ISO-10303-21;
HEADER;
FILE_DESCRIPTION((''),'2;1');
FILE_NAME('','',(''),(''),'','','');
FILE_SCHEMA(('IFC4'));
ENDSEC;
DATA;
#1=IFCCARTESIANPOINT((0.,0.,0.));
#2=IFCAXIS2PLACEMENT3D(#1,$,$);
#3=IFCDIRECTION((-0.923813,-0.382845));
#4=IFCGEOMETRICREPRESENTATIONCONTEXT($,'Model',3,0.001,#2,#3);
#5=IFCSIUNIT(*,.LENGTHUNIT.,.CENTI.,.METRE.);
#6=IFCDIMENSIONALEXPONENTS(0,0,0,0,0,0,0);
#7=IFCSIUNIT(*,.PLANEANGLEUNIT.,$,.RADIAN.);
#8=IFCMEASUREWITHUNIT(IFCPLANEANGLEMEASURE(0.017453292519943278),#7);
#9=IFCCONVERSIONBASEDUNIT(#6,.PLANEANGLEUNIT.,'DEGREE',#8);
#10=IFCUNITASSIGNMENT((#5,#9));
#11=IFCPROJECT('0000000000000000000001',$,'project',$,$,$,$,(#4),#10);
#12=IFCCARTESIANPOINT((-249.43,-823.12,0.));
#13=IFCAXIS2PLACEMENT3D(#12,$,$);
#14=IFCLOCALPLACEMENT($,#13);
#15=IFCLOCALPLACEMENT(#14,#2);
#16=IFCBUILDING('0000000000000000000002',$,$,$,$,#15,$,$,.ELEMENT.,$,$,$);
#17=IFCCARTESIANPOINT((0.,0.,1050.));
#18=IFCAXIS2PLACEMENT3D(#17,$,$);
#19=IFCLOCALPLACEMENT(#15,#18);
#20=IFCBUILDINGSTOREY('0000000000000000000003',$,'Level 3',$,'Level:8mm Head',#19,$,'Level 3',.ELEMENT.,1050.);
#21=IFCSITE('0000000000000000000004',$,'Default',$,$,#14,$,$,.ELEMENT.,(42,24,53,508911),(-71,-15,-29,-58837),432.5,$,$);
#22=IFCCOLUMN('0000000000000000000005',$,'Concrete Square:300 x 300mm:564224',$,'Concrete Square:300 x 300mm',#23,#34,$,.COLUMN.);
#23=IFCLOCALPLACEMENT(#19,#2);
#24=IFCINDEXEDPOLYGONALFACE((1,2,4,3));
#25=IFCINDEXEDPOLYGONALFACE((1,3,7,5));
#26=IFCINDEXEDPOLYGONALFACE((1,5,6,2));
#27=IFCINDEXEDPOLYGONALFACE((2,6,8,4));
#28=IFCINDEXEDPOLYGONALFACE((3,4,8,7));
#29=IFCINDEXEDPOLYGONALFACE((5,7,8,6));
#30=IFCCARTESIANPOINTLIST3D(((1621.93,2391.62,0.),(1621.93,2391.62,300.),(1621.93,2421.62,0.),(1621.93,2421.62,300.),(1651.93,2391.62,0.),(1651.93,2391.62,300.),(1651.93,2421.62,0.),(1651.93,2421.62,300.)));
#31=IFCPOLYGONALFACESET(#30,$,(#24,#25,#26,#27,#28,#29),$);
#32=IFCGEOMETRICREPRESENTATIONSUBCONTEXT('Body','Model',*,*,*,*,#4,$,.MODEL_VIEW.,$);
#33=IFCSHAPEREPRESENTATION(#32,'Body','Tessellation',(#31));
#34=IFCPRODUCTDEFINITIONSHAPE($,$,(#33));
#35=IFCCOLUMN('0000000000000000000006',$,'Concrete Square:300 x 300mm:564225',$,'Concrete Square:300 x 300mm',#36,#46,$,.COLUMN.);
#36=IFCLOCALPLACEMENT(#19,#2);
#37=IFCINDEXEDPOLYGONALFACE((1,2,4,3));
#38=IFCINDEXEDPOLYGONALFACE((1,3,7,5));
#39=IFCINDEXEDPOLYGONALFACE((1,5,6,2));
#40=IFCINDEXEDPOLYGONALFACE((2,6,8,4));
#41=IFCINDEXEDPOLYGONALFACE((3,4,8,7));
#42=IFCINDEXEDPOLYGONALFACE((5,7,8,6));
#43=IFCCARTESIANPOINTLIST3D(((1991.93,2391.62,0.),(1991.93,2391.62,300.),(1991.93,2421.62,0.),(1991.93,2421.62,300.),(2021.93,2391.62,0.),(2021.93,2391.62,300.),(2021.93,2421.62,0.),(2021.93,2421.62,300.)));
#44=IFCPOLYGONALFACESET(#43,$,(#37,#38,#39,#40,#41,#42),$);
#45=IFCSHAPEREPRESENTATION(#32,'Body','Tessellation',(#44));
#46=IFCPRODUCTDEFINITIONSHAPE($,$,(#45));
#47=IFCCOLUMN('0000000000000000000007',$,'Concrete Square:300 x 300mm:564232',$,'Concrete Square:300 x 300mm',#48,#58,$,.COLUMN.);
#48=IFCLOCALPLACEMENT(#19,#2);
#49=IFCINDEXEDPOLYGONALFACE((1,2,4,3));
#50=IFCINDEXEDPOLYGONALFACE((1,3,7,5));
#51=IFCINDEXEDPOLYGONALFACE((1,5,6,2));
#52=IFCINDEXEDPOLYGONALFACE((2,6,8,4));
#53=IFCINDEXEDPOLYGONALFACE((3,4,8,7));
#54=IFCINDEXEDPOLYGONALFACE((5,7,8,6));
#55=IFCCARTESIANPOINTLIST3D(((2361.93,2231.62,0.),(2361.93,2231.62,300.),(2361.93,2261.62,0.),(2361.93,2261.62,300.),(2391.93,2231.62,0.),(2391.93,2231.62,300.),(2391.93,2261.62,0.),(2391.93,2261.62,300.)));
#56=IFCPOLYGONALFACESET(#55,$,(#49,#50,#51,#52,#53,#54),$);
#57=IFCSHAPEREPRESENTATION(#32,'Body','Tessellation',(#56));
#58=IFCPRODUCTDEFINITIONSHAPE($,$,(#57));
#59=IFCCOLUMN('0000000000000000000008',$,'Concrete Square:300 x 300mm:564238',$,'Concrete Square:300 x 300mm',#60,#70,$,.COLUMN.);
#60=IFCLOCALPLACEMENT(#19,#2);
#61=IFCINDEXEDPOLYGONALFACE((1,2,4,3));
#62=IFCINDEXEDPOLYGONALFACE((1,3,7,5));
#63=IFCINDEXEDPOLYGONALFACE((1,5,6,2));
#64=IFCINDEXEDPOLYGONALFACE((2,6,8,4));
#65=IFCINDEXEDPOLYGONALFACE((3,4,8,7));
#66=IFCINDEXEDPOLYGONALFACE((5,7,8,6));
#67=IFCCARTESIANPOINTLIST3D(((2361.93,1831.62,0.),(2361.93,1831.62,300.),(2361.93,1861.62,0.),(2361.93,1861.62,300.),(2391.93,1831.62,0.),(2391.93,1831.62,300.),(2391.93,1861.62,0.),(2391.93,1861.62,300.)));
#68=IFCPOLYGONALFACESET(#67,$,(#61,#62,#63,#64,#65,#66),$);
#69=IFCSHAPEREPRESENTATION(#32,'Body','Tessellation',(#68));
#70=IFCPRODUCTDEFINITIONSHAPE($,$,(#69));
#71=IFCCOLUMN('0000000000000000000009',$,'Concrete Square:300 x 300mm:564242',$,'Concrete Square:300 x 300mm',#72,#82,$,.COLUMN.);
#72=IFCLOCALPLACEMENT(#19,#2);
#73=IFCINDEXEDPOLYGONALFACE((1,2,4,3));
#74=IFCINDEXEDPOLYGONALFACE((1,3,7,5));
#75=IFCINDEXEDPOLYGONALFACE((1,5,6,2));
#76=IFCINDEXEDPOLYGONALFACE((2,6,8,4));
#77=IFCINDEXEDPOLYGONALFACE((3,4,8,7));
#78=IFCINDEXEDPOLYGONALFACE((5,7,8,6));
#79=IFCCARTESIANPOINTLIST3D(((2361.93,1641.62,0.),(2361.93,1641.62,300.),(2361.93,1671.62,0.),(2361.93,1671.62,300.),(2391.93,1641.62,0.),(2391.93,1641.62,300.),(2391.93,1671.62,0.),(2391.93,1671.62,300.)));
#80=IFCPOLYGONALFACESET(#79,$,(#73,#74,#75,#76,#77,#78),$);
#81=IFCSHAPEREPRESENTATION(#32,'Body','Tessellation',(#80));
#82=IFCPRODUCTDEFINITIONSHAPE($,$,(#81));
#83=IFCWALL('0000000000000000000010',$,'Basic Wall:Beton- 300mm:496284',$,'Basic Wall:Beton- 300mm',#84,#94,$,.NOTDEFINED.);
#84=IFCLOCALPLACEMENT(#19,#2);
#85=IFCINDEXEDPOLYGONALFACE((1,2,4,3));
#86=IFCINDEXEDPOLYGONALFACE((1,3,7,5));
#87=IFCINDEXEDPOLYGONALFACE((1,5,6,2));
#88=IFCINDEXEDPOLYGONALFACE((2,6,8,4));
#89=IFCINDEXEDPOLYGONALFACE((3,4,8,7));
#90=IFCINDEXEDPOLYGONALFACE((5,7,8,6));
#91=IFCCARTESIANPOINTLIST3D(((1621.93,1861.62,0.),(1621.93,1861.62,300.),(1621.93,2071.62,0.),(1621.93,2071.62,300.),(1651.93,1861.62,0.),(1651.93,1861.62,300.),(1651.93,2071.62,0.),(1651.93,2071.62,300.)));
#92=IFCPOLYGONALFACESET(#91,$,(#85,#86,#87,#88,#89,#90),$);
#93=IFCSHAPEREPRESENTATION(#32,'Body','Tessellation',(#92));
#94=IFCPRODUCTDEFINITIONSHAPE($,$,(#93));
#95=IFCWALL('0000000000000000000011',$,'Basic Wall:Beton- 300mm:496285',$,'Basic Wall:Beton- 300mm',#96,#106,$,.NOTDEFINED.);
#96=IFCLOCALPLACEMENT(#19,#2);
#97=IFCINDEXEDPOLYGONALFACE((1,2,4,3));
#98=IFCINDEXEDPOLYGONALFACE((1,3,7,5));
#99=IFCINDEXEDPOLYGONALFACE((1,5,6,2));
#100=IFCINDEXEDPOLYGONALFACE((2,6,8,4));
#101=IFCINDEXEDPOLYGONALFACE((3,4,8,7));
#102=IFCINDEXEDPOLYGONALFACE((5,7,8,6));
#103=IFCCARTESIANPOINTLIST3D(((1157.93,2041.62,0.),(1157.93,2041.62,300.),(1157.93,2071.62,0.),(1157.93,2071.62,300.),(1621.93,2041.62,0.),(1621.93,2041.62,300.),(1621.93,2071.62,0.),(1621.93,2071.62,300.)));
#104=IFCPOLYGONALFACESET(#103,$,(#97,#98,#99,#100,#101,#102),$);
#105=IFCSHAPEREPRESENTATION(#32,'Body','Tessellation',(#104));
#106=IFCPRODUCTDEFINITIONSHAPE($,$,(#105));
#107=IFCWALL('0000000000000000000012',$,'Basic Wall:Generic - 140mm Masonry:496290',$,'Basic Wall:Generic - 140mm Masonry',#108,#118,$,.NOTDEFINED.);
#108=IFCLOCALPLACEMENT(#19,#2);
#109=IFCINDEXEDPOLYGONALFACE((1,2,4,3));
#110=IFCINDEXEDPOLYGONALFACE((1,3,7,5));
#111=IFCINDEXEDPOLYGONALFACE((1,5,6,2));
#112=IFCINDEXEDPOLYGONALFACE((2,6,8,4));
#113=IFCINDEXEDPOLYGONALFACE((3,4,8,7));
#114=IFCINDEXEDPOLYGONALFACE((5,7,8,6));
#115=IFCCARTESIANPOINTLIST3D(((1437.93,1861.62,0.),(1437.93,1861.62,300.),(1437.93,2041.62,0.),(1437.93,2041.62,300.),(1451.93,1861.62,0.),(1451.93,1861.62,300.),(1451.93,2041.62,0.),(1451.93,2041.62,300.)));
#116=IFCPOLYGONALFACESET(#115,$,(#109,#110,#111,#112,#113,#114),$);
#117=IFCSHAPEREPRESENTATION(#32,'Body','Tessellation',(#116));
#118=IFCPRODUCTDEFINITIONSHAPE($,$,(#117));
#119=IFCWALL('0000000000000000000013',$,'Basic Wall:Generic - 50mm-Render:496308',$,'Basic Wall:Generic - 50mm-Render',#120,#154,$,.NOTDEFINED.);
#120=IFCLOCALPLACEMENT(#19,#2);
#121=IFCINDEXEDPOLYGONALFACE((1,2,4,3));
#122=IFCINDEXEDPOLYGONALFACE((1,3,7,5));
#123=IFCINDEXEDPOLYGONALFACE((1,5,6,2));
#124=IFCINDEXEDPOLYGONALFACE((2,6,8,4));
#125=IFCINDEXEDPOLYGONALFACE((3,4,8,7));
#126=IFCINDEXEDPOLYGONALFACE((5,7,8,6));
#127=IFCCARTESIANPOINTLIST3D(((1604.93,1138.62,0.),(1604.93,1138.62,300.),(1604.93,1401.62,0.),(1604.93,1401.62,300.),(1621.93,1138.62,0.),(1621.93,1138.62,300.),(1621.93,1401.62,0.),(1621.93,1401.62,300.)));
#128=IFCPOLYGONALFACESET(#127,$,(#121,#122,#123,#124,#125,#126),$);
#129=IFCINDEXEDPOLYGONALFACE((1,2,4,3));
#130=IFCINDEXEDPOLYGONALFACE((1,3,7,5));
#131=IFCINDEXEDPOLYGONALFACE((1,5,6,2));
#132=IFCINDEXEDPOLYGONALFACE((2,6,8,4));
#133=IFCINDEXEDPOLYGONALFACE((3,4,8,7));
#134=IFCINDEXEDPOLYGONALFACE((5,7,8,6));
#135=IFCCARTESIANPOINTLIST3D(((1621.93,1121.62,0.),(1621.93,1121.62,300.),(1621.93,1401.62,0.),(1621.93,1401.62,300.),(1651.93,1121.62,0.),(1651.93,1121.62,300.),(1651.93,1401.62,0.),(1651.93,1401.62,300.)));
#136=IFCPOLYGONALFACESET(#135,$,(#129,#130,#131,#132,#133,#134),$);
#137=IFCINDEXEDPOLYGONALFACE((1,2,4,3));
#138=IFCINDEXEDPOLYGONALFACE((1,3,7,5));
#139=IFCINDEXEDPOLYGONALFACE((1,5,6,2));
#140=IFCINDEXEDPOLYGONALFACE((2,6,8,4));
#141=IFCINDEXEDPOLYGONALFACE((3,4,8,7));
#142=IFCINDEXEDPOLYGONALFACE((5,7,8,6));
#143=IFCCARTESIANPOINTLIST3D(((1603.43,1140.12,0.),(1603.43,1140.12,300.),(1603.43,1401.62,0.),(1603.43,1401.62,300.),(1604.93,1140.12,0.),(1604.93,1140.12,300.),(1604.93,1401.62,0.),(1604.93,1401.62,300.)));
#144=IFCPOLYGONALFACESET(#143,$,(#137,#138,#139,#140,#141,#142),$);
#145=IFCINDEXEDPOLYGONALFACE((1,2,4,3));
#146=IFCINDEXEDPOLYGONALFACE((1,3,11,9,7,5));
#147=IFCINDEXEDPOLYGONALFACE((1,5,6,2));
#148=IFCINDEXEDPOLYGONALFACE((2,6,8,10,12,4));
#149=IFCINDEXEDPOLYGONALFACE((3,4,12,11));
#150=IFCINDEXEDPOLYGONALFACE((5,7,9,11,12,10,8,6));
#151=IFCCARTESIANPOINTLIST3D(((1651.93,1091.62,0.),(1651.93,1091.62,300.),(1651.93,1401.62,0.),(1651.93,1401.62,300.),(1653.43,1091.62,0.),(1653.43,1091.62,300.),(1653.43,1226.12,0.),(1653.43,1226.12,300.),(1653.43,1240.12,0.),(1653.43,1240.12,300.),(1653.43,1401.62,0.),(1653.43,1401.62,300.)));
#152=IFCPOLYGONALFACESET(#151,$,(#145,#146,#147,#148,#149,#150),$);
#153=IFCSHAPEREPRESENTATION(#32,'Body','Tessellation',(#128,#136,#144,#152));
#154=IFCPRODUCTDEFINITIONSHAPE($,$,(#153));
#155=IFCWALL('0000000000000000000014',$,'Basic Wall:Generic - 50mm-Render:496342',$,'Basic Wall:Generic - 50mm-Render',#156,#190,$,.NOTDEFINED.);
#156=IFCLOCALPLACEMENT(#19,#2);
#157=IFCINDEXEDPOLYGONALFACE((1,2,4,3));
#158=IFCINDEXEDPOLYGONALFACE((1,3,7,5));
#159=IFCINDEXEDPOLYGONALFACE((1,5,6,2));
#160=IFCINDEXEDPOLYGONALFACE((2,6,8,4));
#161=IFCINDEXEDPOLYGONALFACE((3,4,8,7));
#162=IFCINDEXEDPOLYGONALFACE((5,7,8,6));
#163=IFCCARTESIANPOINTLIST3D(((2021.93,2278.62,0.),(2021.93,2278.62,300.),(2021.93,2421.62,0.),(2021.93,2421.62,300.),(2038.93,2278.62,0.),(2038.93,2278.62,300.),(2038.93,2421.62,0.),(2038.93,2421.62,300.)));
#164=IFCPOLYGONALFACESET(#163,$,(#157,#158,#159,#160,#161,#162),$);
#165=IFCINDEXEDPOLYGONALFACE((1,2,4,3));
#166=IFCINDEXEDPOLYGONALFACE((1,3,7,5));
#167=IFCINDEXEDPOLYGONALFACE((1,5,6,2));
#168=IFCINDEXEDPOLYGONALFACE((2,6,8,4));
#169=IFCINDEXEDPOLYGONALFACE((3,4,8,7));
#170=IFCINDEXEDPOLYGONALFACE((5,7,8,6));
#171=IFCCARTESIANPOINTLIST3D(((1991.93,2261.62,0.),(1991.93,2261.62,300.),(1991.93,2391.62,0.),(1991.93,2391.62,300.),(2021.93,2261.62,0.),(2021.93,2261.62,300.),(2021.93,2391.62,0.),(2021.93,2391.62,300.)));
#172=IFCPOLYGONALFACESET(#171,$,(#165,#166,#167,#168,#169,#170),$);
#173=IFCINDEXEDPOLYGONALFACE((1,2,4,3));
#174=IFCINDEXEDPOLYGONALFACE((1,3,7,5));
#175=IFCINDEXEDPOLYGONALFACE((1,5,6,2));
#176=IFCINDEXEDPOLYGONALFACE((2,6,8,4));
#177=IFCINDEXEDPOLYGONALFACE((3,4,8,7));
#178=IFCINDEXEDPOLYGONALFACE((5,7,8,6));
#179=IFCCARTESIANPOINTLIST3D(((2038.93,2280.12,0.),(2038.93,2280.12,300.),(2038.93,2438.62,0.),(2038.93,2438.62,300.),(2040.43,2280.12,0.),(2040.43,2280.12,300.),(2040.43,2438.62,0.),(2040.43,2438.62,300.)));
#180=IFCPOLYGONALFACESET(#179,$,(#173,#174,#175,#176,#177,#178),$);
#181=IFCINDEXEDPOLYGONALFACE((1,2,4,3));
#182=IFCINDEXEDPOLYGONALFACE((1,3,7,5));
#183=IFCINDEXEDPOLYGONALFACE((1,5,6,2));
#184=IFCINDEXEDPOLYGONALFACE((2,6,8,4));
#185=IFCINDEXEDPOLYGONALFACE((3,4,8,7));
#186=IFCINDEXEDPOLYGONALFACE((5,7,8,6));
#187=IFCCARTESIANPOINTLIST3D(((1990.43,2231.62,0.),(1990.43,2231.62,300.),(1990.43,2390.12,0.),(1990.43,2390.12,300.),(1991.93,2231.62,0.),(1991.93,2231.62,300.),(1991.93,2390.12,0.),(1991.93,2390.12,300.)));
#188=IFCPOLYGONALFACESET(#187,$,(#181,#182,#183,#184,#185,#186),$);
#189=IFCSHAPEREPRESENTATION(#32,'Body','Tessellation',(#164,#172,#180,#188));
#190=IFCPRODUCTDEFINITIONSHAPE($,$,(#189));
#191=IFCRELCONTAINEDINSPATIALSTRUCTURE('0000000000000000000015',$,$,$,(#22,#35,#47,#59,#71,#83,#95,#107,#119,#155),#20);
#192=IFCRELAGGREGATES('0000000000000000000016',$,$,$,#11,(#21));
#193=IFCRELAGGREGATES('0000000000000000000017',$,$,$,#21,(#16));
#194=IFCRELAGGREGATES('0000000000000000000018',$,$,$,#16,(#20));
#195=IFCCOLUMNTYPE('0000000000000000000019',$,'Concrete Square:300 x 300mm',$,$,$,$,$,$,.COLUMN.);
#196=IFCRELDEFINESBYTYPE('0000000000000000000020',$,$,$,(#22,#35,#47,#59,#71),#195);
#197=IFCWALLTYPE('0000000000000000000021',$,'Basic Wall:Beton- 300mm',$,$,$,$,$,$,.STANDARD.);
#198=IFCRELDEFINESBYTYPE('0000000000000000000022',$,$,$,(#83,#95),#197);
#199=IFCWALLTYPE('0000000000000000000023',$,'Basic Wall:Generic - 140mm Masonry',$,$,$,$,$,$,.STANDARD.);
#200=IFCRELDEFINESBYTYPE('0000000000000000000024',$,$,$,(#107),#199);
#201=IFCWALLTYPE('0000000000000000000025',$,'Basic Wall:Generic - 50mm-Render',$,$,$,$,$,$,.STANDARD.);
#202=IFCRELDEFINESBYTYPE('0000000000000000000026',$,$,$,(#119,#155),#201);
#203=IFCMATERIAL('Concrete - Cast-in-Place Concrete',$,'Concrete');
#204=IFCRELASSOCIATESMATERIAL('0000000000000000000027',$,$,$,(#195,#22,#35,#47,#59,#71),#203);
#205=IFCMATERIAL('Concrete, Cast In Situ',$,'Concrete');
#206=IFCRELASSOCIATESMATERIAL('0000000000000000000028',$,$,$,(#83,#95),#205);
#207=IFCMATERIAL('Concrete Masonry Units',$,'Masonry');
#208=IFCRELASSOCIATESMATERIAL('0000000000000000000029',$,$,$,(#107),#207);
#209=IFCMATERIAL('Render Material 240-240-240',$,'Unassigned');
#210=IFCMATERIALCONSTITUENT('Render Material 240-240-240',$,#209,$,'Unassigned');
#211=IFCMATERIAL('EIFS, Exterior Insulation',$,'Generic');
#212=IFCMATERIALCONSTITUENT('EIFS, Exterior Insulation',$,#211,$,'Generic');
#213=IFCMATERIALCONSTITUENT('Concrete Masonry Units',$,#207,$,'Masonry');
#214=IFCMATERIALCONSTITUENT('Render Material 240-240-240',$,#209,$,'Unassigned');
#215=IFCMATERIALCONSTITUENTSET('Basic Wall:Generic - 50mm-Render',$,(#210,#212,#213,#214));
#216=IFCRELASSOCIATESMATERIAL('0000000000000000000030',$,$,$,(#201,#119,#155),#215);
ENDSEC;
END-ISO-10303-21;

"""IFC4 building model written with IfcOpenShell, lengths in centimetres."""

from ifc_helpers import new_model, entity, si_unit, converted_unit, direction, frame, origin, place, context, subcontext, project, spatial, indexed_curve, outline, extrude, source, transform, mapped, material, constituent, constituent_set, type_object, type_shapes, element, save


model = new_model("IFC4")

# Units and contexts
model_context = context("Model", 3, precision=0.001, world=origin(), true_north=direction((-0.923813, -0.382845)))
body_context = subcontext(model_context, "Body", "Model", "MODEL_VIEW")
ifc_project = project(units=[si_unit("LENGTHUNIT", "METRE", prefix="CENTI"), converted_unit("PLANEANGLEUNIT", "DEGREE", entity("IfcPlaneAngleMeasure", 0.017453292519943278), si_unit("PLANEANGLEUNIT", "RADIAN"), dimensions=[0, 0, 0, 0, 0, 0, 0])], contexts=[model_context])

# Site, building, storey
site_placement = place(None, frame((-249.43, -823.12, 0.0)))
site = spatial("IfcSite", under=ifc_project, at=site_placement, Name="Default", CompositionType="ELEMENT", RefLatitude=(42, 24, 53, 508911), RefLongitude=(-71, -15, -29, -58837), RefElevation=432.5)
building_placement = place(site_placement, origin())
building = spatial("IfcBuilding", under=site, at=building_placement, CompositionType="ELEMENT")
storey_placement = place(building_placement, frame((0.0, 0.0, 1050.0)))
storey = spatial("IfcBuildingStorey", under=building, at=storey_placement, Name="Level 3", ObjectType="Level:8mm Head", LongName="Level 3", CompositionType="ELEMENT", Elevation=1050.0)

# Columns
ifc_material_1 = material(Name="Concrete - Cast-in-Place Concrete", Category="Concrete")
column_type = type_object("IfcColumnType", Name="Concrete Square:300 x 300mm", PredefinedType="COLUMN", material=ifc_material_1)
shared_shape_1 = source(origin(), body_context, "Body", "SweptSolid", [
    extrude(outline(indexed_curve([(-15.0, -15.0), (15.0, -15.0), (15.0, 15.0), (-15.0, 15.0), (-15.0, -15.0)], self_intersect=False)), frame((0.0, 0.0, 1050.0), z_axis=(0.0, 0.0, 1.0), x_axis=(-1.0, 0.0, 0.0)), (0.0, 0.0, 1.0), 300.0),
])
type_shapes(column_type, [shared_shape_1])
for number, where, name in (
    (1, (1636.93, 2406.62, -1050.0), "Concrete Square:300 x 300mm:564224"),
    (2, (2006.93, 2406.62, -1050.0), "Concrete Square:300 x 300mm:564225"),
    (3, (2376.93, 2246.62, -1050.0), "Concrete Square:300 x 300mm:564232"),
    (4, (2376.93, 1846.62, -1050.0), "Concrete Square:300 x 300mm:564238"),
    (5, (2376.93, 1656.62, -1050.0), "Concrete Square:300 x 300mm:564242"),
):
    element("IfcColumn", number, at=place(storey_placement, frame(where)), inside=storey, type_object=column_type, material=ifc_material_1, Name=name, ObjectType="Concrete Square:300 x 300mm", PredefinedType="COLUMN", context=body_context, shape_type="MappedRepresentation", body=[
        mapped(shared_shape_1, transform((0.0, 0.0, 0.0), scale=1.0)),
    ])

# Walls
ifc_material_2 = material(Name="Concrete, Cast In Situ", Category="Concrete")
wall_type_1 = type_object("IfcWallType", Name="Basic Wall:Beton- 300mm", PredefinedType="STANDARD")
wall_1_placement = place(storey_placement, frame((1636.93, 1861.62, 0.0), z_axis=(0.0, 0.0, 1.0), x_axis=(0.0, 1.0, 0.0)))
element("IfcWall", 6, at=wall_1_placement, inside=storey, type_object=wall_type_1, material=ifc_material_2, Name="Basic Wall:Beton- 300mm:496284", ObjectType="Basic Wall:Beton- 300mm", PredefinedType="NOTDEFINED", context=body_context, shape_type="SweptSolid", body=[
    extrude(outline(indexed_curve([(210.0, 15.0), (0.0, 15.0), (0.0, -15.0), (210.0, -15.0), (210.0, 15.0)], self_intersect=False)), origin(), (0.0, 0.0, 1.0), 300.0),
])
wall_2_placement = place(storey_placement, frame((1621.93, 2056.62, 0.0), z_axis=(0.0, 0.0, 1.0), x_axis=(-1.0, 0.0, 0.0)))
element("IfcWall", 7, at=wall_2_placement, inside=storey, type_object=wall_type_1, material=ifc_material_2, Name="Basic Wall:Beton- 300mm:496285", ObjectType="Basic Wall:Beton- 300mm", PredefinedType="NOTDEFINED", context=body_context, shape_type="SweptSolid", body=[
    extrude(outline(indexed_curve([(464.0, 15.0), (0.0, 15.0), (0.0, -15.0), (464.0, -15.0), (464.0, 15.0)], self_intersect=False)), origin(), (0.0, 0.0, 1.0), 300.0),
])
ifc_material_3 = material(Name="Concrete Masonry Units", Category="Masonry")
wall_type_2 = type_object("IfcWallType", Name="Basic Wall:Generic - 140mm Masonry", PredefinedType="STANDARD")
wall_3_placement = place(storey_placement, frame((1444.93, 2041.62, 0.0), z_axis=(0.0, 0.0, 1.0), x_axis=(0.0, -1.0, 0.0)))
element("IfcWall", 8, at=wall_3_placement, inside=storey, type_object=wall_type_2, material=ifc_material_3, Name="Basic Wall:Generic - 140mm Masonry:496290", ObjectType="Basic Wall:Generic - 140mm Masonry", PredefinedType="NOTDEFINED", context=body_context, shape_type="SweptSolid", body=[
    extrude(outline(indexed_curve([(180.0, 7.0), (0.0, 7.0), (0.0, -7.0), (180.0, -7.0), (180.0, 7.0)], self_intersect=False)), origin(), (0.0, 0.0, 1.0), 300.0),
])
ifc_material_4 = material(Name="Render Material 240-240-240", Category="Unassigned")
ifc_constituent_1 = constituent(ifc_material_4, Name="Render Material 240-240-240", Category="Unassigned")
ifc_material_5 = material(Name="EIFS, Exterior Insulation", Category="Generic")
ifc_constituent_2 = constituent(ifc_material_5, Name="EIFS, Exterior Insulation", Category="Generic")
ifc_constituent_3 = constituent(ifc_material_3, Name="Concrete Masonry Units", Category="Masonry")
ifc_constituent_4 = constituent(ifc_material_4, Name="Render Material 240-240-240", Category="Unassigned")
ifc_constituent_set_1 = constituent_set(constituents=[ifc_constituent_1, ifc_constituent_2, ifc_constituent_3, ifc_constituent_4], Name="Basic Wall:Generic - 50mm-Render")
wall_type_3 = type_object("IfcWallType", Name="Basic Wall:Generic - 50mm-Render", PredefinedType="STANDARD", material=ifc_constituent_set_1)
wall_4_placement = place(storey_placement, frame((1628.43, 1401.62, 0.0), z_axis=(0.0, 0.0, 1.0), x_axis=(0.0, -1.0, 0.0)))
element("IfcWall", 9, at=wall_4_placement, inside=storey, type_object=wall_type_3, material=ifc_constituent_set_1, Name="Basic Wall:Generic - 50mm-Render:496308", ObjectType="Basic Wall:Generic - 50mm-Render", PredefinedType="NOTDEFINED", context=body_context, shape_type="SweptSolid", body=[
    extrude(outline(indexed_curve([(-8.5, -131.5), (8.5, -131.5), (8.5, 131.5), (-8.5, 131.5), (-8.5, -131.5)], self_intersect=False)), frame((131.5, -15.0, 0.0), z_axis=(0.0, 0.0, 1.0), x_axis=(0.0, 1.0, 0.0)), (0.0, 0.0, 1.0), 300.0),
    extrude(outline(indexed_curve([(-15.0, -140.0), (15.0, -140.0), (15.0, 140.0), (-15.0, 140.0), (-15.0, -140.0)], self_intersect=False)), frame((140.0, 8.5, 0.0), z_axis=(0.0, 0.0, 1.0), x_axis=(0.0, -1.0, 0.0)), (0.0, 0.0, 1.0), 300.0),
    extrude(outline(indexed_curve([(-0.75, -130.75), (0.75, -130.75), (0.75, 130.75), (-0.75, 130.75), (-0.75, -130.75)], self_intersect=False)), frame((130.75, -24.25, 0.0), z_axis=(0.0, 0.0, 1.0), x_axis=(0.0, 1.0, 0.0)), (0.0, 0.0, 1.0), 300.0),
    extrude(outline(indexed_curve([(-1.0, -150.5), (0.5, -150.5), (0.5, -16.0), (0.5, -2.0), (0.5, 159.5), (-1.0, 159.5), (-1.0, -150.5)], self_intersect=False)), frame((159.5, 24.5, 0.0), z_axis=(0.0, 0.0, 1.0), x_axis=(0.0, 1.0, 0.0)), (0.0, 0.0, 1.0), 300.0),
])
wall_5_placement = place(storey_placement, frame((2015.43, 2280.12, 0.0), z_axis=(0.0, 0.0, 1.0), x_axis=(0.0, 1.0, 0.0)))
element("IfcWall", 10, at=wall_5_placement, inside=storey, type_object=wall_type_3, material=ifc_constituent_set_1, Name="Basic Wall:Generic - 50mm-Render:496342", ObjectType="Basic Wall:Generic - 50mm-Render", PredefinedType="NOTDEFINED", context=body_context, shape_type="SweptSolid", body=[
    extrude(outline(indexed_curve([(-8.5, -71.5), (8.5, -71.5), (8.5, 71.5), (-8.5, 71.5), (-8.5, -71.5)], self_intersect=False)), frame((70.0, -15.0, 0.0), z_axis=(0.0, 0.0, 1.0), x_axis=(0.0, 1.0, 0.0)), (0.0, 0.0, 1.0), 300.0),
    extrude(outline(indexed_curve([(-15.0, -65.0), (15.0, -65.0), (15.0, 65.0), (-15.0, 65.0), (-15.0, -65.0)], self_intersect=False)), frame((46.5, 8.5, 0.0), z_axis=(0.0, 0.0, 1.0), x_axis=(0.0, -1.0, 0.0)), (0.0, 0.0, 1.0), 300.0),
    extrude(outline(indexed_curve([(-0.75, -79.25), (0.75, -79.25), (0.75, 79.25), (-0.75, 79.25), (-0.75, -79.25)], self_intersect=False)), frame((79.25, -24.25, 0.0), z_axis=(0.0, 0.0, 1.0), x_axis=(0.0, 1.0, 0.0)), (0.0, 0.0, 1.0), 300.0),
    extrude(outline(indexed_curve([(-0.75, -79.25), (0.75, -79.25), (0.75, 79.25), (-0.75, 79.25), (-0.75, -79.25)], self_intersect=False)), frame((30.75, 24.25, 0.0), z_axis=(0.0, 0.0, 1.0), x_axis=(0.0, 1.0, 0.0)), (0.0, 0.0, 1.0), 300.0),
])

save(model, "model.ifc")
